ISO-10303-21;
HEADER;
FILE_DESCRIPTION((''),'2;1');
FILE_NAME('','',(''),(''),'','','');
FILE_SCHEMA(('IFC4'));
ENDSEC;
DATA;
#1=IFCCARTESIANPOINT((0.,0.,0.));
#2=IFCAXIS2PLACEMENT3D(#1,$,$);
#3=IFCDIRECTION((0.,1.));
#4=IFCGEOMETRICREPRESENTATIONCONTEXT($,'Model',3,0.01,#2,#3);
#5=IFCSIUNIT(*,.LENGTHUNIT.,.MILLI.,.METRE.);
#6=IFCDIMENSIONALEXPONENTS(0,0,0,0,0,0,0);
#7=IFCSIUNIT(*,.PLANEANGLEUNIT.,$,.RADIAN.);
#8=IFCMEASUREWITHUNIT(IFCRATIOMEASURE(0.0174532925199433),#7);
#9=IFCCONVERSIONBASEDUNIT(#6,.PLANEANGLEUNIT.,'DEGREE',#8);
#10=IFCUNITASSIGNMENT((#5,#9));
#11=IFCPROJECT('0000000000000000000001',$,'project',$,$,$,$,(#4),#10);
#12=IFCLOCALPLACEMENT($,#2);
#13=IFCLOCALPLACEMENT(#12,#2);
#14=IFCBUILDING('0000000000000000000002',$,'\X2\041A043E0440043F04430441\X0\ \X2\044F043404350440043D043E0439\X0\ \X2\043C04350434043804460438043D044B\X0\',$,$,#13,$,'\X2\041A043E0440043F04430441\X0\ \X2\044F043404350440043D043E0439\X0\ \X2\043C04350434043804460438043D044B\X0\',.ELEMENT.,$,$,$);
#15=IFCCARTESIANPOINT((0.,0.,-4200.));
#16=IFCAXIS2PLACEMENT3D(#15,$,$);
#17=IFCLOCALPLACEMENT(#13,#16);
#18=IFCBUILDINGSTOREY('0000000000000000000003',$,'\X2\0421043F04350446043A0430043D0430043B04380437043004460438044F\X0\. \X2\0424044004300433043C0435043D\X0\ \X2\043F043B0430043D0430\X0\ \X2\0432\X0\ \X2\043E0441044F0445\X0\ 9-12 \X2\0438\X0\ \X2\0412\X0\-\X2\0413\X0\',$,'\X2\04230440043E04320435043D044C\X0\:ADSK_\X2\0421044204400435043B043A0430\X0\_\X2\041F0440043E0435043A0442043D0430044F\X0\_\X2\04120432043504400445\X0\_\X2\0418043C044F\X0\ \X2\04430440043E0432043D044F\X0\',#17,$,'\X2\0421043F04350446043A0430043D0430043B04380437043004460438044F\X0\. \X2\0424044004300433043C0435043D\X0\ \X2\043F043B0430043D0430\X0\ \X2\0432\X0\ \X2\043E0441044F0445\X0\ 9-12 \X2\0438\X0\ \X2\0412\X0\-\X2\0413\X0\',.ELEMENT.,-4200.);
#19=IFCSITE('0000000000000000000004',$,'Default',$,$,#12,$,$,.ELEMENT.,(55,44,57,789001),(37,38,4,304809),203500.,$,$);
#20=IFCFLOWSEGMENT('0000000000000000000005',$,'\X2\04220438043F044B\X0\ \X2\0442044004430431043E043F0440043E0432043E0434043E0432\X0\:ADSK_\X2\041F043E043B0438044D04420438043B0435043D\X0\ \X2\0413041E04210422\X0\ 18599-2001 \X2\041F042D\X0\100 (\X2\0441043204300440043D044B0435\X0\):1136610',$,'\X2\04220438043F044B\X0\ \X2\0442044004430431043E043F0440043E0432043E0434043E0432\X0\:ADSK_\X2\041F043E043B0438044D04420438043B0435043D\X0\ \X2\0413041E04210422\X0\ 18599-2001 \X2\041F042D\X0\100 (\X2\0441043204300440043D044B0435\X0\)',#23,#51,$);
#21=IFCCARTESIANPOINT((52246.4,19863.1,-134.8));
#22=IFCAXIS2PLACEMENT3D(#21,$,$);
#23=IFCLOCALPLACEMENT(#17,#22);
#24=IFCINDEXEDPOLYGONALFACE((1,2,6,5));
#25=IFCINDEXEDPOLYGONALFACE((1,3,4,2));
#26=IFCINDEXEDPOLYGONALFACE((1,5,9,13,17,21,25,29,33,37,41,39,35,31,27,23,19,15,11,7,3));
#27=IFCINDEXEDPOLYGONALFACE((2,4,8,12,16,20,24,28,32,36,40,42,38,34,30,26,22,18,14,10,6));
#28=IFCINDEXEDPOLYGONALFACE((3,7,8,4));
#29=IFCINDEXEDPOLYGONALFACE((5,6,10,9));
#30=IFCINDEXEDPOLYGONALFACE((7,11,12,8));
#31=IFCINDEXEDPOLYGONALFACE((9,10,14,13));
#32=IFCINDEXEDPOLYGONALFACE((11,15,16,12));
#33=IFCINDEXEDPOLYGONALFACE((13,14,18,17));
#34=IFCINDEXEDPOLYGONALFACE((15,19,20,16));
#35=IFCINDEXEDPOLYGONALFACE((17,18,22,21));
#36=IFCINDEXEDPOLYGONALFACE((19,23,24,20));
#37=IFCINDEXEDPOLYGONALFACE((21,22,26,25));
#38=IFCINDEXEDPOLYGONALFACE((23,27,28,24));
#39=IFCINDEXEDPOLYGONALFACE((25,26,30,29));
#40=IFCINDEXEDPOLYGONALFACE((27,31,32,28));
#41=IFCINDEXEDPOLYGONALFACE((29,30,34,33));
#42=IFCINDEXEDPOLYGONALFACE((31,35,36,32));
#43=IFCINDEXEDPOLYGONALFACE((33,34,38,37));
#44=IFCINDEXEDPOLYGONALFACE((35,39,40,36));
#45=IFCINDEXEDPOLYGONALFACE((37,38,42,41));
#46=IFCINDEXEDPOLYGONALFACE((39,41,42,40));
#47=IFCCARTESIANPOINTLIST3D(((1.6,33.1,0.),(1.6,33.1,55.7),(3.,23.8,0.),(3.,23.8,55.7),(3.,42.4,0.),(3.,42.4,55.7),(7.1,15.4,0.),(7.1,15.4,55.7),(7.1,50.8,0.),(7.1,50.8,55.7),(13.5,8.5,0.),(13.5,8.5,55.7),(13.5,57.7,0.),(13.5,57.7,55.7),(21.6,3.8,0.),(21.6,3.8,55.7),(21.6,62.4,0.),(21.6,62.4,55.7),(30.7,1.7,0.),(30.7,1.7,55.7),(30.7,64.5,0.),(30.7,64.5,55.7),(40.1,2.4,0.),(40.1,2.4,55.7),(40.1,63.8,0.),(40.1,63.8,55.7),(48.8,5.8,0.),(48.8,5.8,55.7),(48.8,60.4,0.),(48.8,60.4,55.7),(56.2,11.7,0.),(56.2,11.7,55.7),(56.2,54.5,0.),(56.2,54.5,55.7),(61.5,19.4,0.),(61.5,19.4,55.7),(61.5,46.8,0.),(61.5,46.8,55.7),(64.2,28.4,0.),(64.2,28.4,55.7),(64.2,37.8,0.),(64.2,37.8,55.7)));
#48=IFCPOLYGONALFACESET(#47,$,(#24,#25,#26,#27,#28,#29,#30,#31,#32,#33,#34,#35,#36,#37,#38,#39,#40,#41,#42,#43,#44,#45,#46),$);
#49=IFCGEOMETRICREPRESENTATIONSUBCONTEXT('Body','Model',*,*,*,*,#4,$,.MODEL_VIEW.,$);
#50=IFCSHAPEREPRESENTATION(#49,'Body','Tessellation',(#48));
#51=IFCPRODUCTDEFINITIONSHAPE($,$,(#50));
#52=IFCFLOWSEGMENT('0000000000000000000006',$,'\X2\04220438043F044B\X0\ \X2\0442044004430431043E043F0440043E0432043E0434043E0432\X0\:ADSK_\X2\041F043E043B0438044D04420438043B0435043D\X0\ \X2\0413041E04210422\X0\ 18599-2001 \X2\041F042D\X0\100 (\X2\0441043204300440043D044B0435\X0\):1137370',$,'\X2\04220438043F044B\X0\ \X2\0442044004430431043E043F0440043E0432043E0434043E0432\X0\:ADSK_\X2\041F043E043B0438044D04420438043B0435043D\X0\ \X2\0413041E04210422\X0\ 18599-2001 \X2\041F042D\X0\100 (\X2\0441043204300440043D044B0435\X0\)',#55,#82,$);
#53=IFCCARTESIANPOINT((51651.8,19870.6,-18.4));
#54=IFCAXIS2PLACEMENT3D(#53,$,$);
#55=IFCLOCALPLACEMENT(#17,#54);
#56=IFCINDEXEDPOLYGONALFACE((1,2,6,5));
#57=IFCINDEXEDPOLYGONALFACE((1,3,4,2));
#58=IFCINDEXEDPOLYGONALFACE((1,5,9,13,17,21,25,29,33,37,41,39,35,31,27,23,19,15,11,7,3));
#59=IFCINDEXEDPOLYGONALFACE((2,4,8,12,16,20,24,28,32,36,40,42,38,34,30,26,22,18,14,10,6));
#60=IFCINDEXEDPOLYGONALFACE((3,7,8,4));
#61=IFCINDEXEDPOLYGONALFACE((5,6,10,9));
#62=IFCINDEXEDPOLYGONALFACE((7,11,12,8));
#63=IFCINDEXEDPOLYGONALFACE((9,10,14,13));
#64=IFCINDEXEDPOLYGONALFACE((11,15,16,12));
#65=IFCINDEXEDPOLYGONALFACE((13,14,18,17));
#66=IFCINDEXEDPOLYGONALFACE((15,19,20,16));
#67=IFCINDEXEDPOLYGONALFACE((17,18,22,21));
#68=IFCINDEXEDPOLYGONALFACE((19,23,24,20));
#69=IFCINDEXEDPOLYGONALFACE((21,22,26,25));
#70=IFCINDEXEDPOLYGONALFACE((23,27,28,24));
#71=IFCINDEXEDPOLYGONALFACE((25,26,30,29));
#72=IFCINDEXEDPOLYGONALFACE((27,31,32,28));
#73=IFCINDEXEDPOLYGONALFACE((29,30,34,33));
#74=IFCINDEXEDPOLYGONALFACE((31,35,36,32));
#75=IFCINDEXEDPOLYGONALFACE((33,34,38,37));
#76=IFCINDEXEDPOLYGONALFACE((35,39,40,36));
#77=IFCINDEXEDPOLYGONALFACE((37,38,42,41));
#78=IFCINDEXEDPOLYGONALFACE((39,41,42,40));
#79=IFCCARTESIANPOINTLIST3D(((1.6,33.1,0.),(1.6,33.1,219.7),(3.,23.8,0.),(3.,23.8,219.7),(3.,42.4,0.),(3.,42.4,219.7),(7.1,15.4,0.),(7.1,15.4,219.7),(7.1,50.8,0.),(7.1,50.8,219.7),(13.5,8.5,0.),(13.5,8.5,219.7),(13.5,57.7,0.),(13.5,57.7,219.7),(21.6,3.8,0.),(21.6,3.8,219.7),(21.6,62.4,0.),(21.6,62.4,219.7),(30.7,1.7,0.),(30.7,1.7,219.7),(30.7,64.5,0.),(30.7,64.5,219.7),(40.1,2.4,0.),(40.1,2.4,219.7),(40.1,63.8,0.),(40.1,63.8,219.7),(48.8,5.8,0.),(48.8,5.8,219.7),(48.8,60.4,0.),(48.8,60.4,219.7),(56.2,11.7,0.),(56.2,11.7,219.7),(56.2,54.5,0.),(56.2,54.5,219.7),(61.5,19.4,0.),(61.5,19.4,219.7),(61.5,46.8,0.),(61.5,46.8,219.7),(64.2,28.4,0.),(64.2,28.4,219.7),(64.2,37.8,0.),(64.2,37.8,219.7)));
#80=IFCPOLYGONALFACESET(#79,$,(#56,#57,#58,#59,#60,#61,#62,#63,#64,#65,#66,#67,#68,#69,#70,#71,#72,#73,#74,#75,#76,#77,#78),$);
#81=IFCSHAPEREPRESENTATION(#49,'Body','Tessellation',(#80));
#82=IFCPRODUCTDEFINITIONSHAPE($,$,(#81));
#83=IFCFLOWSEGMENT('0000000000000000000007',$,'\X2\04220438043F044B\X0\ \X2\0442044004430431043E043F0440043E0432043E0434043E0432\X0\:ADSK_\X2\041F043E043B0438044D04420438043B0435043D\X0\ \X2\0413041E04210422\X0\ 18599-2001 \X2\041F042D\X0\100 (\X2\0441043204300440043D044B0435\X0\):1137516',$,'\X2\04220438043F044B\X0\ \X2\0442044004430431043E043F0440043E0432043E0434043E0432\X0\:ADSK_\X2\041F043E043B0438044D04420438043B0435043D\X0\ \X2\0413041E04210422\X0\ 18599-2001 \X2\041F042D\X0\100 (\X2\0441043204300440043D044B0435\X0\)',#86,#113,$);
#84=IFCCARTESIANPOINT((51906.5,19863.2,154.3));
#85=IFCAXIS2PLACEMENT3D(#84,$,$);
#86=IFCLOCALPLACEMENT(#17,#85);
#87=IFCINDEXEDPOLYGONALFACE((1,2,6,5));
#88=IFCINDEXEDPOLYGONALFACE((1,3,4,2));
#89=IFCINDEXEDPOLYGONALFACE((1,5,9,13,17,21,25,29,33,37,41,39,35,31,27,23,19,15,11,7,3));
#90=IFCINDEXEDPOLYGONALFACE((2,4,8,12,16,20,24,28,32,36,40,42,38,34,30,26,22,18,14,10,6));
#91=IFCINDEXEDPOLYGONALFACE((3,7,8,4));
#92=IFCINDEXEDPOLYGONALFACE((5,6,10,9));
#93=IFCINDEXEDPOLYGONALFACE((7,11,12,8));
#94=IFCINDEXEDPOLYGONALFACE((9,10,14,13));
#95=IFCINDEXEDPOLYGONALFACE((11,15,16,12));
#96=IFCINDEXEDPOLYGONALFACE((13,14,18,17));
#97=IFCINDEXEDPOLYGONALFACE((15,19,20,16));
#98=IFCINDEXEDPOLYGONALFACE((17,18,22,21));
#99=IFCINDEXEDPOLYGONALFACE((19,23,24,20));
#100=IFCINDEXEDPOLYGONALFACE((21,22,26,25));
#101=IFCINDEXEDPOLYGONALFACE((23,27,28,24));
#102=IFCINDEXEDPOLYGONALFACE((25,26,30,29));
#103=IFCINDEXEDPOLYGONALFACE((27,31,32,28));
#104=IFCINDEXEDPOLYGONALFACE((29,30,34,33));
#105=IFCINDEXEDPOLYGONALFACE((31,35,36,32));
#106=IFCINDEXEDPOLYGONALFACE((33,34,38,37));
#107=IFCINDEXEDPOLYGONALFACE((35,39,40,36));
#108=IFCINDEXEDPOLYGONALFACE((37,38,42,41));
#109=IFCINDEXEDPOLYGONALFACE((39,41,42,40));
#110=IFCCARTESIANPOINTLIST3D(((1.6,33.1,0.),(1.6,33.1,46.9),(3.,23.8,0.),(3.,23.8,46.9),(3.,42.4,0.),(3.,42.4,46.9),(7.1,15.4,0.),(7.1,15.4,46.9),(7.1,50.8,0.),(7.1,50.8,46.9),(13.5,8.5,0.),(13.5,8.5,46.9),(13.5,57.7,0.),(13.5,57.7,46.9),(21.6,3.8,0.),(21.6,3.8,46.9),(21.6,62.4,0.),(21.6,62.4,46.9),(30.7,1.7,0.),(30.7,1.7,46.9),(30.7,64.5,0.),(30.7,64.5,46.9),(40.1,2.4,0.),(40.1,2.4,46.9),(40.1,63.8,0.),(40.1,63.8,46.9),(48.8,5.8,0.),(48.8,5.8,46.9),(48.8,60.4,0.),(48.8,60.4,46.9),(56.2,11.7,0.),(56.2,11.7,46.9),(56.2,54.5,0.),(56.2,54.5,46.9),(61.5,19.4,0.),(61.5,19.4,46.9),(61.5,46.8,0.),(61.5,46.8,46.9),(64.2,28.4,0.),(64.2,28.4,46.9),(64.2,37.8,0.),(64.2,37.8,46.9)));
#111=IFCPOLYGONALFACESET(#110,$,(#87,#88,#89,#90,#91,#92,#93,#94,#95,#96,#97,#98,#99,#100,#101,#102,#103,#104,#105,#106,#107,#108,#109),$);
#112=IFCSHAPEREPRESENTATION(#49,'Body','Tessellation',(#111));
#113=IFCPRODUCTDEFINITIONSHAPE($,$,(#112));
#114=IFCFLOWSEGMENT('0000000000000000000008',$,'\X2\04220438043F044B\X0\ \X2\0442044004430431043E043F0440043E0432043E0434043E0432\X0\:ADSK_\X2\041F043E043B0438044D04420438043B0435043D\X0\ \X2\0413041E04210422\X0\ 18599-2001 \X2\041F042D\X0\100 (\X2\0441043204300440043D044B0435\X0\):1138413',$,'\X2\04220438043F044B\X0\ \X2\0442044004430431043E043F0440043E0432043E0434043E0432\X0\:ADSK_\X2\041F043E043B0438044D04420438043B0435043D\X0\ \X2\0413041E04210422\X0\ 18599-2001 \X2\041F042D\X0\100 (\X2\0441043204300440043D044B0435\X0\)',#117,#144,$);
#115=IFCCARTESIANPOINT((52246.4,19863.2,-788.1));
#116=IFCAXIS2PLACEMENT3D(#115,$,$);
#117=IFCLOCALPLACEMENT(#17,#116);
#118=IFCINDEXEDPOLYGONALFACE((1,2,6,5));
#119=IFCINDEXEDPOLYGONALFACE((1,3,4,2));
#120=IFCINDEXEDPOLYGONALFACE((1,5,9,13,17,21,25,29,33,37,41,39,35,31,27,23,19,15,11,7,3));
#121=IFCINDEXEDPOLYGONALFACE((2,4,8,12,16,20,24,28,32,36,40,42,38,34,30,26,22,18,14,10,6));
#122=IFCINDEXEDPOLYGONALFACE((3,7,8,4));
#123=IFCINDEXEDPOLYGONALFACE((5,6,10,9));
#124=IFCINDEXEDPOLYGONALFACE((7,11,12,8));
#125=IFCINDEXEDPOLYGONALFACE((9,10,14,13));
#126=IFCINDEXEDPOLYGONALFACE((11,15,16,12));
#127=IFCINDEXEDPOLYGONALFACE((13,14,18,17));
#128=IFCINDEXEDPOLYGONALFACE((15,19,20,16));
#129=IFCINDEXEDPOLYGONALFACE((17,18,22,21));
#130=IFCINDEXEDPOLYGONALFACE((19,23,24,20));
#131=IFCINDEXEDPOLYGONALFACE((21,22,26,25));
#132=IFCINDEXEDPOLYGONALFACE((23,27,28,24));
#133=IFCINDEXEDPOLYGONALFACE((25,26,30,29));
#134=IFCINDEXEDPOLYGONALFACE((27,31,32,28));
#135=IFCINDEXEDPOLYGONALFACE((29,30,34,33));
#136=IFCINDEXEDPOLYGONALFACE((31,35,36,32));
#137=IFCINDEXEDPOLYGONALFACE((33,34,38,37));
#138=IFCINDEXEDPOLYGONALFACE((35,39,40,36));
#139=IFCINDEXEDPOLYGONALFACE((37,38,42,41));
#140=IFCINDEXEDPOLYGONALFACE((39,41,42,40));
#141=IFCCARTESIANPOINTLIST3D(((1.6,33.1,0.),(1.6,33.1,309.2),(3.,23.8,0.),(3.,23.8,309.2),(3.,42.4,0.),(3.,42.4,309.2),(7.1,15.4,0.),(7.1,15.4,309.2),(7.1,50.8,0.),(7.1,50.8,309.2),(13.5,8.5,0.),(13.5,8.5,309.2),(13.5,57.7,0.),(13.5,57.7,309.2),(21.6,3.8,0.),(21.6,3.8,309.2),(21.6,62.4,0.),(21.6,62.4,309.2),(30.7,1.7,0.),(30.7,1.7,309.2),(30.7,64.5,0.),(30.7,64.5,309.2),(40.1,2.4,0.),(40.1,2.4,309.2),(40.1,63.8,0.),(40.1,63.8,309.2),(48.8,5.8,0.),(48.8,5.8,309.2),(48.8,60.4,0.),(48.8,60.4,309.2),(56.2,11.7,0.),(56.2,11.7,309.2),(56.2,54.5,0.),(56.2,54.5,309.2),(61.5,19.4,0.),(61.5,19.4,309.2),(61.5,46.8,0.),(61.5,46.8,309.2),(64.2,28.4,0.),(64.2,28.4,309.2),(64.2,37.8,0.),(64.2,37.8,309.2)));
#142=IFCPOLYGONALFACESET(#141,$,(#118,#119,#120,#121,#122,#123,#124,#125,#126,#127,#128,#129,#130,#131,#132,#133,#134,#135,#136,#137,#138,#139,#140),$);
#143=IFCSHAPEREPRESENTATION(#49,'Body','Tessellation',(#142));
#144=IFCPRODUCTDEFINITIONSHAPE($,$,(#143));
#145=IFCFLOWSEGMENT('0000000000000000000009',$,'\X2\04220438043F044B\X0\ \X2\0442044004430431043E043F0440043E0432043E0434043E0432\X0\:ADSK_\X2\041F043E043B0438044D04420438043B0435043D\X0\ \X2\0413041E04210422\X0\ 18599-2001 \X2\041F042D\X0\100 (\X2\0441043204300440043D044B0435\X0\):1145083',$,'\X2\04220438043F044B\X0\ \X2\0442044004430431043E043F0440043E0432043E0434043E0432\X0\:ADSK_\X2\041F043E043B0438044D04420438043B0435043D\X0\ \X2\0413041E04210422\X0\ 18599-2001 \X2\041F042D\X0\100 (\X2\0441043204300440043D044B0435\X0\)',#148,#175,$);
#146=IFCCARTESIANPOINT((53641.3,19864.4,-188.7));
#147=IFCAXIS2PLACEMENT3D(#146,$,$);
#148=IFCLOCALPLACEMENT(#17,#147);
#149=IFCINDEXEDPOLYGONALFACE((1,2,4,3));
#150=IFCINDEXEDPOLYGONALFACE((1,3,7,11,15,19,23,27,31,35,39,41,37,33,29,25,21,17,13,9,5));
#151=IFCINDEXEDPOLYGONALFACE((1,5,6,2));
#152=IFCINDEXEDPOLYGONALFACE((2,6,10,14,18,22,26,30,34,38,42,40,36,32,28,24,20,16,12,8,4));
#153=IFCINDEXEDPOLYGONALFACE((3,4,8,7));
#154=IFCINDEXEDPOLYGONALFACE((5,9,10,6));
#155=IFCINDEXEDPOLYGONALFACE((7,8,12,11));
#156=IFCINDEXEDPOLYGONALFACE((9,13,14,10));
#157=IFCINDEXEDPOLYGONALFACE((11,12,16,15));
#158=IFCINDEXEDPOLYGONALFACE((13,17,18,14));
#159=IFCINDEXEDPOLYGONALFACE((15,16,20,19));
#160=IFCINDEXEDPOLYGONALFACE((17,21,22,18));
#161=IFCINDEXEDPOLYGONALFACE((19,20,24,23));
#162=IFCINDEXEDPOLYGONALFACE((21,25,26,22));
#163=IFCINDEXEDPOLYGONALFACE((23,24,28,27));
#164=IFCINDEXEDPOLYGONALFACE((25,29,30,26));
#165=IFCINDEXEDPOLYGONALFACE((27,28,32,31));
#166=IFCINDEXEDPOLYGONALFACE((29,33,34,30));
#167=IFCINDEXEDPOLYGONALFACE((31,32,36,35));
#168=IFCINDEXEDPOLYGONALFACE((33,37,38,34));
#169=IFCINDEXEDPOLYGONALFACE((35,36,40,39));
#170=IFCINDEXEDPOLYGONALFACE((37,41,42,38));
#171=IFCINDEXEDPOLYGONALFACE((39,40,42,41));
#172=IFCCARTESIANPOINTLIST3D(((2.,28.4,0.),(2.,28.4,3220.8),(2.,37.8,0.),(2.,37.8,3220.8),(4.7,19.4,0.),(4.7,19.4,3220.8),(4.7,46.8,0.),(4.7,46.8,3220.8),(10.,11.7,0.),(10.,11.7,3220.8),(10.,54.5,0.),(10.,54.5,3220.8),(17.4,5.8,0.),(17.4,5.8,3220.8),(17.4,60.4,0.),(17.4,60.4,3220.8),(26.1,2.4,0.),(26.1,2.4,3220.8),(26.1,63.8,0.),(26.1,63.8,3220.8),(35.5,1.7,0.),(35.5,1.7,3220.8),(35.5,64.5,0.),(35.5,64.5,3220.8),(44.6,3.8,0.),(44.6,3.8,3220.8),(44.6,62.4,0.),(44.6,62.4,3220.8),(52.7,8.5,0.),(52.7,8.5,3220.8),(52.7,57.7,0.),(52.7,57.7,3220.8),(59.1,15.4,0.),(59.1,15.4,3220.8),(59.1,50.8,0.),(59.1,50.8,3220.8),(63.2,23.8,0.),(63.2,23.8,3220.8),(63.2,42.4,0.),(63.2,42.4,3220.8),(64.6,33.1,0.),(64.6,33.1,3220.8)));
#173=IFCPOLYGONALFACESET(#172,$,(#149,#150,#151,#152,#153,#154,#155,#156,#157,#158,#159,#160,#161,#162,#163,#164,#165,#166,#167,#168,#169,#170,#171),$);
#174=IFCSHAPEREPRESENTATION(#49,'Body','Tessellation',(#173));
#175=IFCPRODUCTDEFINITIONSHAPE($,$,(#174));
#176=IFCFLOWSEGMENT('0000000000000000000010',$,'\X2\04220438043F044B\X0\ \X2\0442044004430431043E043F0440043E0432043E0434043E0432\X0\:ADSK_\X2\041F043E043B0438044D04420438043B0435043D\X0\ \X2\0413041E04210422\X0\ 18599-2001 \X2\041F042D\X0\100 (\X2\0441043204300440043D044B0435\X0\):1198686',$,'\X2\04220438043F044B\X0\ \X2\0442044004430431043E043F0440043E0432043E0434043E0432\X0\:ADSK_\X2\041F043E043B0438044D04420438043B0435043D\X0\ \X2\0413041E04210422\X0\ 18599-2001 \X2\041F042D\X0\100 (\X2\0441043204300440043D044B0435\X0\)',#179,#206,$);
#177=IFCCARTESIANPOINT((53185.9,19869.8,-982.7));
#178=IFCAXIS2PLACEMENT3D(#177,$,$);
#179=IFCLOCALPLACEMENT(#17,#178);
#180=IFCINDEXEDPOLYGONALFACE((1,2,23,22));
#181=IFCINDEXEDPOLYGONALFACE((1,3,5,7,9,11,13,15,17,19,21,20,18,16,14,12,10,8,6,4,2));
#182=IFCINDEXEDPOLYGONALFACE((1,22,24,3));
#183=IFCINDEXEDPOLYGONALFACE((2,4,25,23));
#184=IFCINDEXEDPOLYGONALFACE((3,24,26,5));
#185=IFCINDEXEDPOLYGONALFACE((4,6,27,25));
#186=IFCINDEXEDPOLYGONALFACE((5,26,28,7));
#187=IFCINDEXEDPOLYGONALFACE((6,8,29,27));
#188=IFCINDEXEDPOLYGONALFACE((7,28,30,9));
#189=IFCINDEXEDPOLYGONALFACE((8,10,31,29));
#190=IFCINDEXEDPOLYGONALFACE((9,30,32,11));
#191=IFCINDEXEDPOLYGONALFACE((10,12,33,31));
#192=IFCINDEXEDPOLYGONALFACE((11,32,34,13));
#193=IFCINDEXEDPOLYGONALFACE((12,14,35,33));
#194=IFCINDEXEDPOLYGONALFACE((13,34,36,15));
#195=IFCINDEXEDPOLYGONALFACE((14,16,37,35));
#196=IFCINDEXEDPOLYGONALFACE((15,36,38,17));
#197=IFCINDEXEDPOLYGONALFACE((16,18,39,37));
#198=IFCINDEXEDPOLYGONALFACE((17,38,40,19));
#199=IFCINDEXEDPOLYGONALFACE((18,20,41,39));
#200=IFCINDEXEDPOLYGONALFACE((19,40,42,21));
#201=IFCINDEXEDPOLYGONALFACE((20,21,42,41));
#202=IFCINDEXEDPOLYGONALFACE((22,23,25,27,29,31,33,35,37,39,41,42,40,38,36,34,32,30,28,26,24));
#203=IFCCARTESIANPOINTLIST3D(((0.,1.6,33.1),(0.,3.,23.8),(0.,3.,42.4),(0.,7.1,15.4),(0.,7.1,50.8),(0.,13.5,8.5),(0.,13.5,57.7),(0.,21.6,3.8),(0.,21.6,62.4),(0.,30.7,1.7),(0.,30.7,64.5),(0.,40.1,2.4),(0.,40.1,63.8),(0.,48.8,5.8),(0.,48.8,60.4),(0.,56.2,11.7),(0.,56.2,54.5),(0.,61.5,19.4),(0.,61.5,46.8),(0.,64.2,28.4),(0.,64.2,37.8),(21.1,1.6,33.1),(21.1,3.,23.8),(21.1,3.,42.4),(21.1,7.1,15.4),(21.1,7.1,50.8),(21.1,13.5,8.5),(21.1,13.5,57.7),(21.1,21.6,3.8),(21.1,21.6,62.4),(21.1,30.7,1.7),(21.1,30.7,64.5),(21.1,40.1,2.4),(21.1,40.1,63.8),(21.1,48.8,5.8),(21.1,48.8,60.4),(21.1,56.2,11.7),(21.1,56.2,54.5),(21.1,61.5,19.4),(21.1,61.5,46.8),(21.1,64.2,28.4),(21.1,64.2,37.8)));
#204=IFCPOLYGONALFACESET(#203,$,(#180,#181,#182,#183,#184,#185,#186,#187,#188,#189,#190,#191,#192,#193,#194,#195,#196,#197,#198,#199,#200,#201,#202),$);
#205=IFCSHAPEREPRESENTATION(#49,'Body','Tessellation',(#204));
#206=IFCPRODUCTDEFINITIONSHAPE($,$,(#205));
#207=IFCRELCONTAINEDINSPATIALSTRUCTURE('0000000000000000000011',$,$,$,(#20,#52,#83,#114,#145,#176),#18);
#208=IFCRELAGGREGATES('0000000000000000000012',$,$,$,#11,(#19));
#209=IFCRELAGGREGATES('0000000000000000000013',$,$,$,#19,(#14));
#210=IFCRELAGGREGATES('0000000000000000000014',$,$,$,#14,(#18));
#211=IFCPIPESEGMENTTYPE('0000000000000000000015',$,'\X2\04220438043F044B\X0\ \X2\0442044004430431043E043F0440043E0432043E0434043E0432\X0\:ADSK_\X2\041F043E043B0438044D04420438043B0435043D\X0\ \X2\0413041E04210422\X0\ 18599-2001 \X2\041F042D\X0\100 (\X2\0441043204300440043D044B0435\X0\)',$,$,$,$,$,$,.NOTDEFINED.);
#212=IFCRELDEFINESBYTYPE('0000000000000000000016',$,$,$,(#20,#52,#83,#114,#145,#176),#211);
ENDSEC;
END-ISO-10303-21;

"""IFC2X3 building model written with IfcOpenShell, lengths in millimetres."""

from ifc_helpers import new_model, entity, si_unit, converted_unit, direction, frame, frame_2d, origin, origin_2d_with_axis, place, context, subcontext, project, spatial, circle, extrude, type_object, element, save


model = new_model("IFC2X3")

# Units and contexts
model_context = context("Model", 3, precision=0.01, world=origin(), true_north=direction((0.0, 1.0)))
body_context = subcontext(model_context, "Body", "Model", "MODEL_VIEW")
ifc_project = project(units=[si_unit("LENGTHUNIT", "METRE", prefix="MILLI"), converted_unit("PLANEANGLEUNIT", "DEGREE", entity("IfcRatioMeasure", 0.0174532925199433), si_unit("PLANEANGLEUNIT", "RADIAN"), dimensions=[0, 0, 0, 0, 0, 0, 0])], contexts=[model_context])

# Site, building, storey
site_placement = place(None, frame((0.0, 0.0, 0.0)))
site = spatial("IfcSite", under=ifc_project, at=site_placement, Name="Default", CompositionType="ELEMENT", RefLatitude=(55, 44, 57, 789001), RefLongitude=(37, 38, 4, 304809), RefElevation=203500.0)
building_placement = place(site_placement, origin())
building = spatial("IfcBuilding", under=site, at=building_placement, Name="Корпус ядерной медицины", LongName="Корпус ядерной медицины", CompositionType="ELEMENT")
storey_placement = place(building_placement, frame((0.0, 0.0, -4200.0)))
storey = spatial("IfcBuildingStorey", under=building, at=storey_placement, Name="Спецканализация. Фрагмен плана в осях 9-12 и В-Г", ObjectType="Уровень:ADSK_Стрелка_Проектная_Вверх_Имя уровня", LongName="Спецканализация. Фрагмен плана в осях 9-12 и В-Г", CompositionType="ELEMENT", Elevation=-4200.0)

# Flow segments
pipe_segment_type = type_object("IfcPipeSegmentType", Name="Типы трубопроводов:ADSK_Полиэтилен ГОСТ 18599-2001 ПЭ100 (сварные)", PredefinedType="NOTDEFINED")
flow_segment_1_placement = place(storey_placement, frame((52246.4, 19863.1, -134.8)))
element("IfcFlowSegment", 1, at=flow_segment_1_placement, inside=storey, type_object=pipe_segment_type, Name="Типы трубопроводов:ADSK_Полиэтилен ГОСТ 18599-2001 ПЭ100 (сварные):1136610", ObjectType="Типы трубопроводов:ADSK_Полиэтилен ГОСТ 18599-2001 ПЭ100 (сварные)", context=body_context, shape_type="SweptSolid", body=[
    extrude(circle(Radius=31.5, at=origin_2d_with_axis()), frame((33.1, 33.1, 0.0), z_axis=(0.0, 0.0, 1.0), x_axis=(-1.0, 0.0, 0.0)), (0.0, 0.0, 1.0), 55.7),
])
flow_segment_2_placement = place(storey_placement, frame((51651.8, 19870.6, -18.4)))
element("IfcFlowSegment", 2, at=flow_segment_2_placement, inside=storey, type_object=pipe_segment_type, Name="Типы трубопроводов:ADSK_Полиэтилен ГОСТ 18599-2001 ПЭ100 (сварные):1137370", ObjectType="Типы трубопроводов:ADSK_Полиэтилен ГОСТ 18599-2001 ПЭ100 (сварные)", context=body_context, shape_type="SweptSolid", body=[
    extrude(circle(Radius=31.5, at=origin_2d_with_axis()), frame((33.1, 33.1, 0.0), z_axis=(0.0, 0.0, 1.0), x_axis=(-1.0, 0.0, 0.0)), (0.0, 0.0, 1.0), 219.7),
])
flow_segment_3_placement = place(storey_placement, frame((51906.5, 19863.2, 154.3)))
element("IfcFlowSegment", 3, at=flow_segment_3_placement, inside=storey, type_object=pipe_segment_type, Name="Типы трубопроводов:ADSK_Полиэтилен ГОСТ 18599-2001 ПЭ100 (сварные):1137516", ObjectType="Типы трубопроводов:ADSK_Полиэтилен ГОСТ 18599-2001 ПЭ100 (сварные)", context=body_context, shape_type="SweptSolid", body=[
    extrude(circle(Radius=31.5, at=origin_2d_with_axis()), frame((33.1, 33.1, 0.0), z_axis=(0.0, 0.0, 1.0), x_axis=(-1.0, 0.0, 0.0)), (0.0, 0.0, 1.0), 46.9),
])
flow_segment_4_placement = place(storey_placement, frame((52246.4, 19863.2, -788.1)))
element("IfcFlowSegment", 4, at=flow_segment_4_placement, inside=storey, type_object=pipe_segment_type, Name="Типы трубопроводов:ADSK_Полиэтилен ГОСТ 18599-2001 ПЭ100 (сварные):1138413", ObjectType="Типы трубопроводов:ADSK_Полиэтилен ГОСТ 18599-2001 ПЭ100 (сварные)", context=body_context, shape_type="SweptSolid", body=[
    extrude(circle(Radius=31.5, at=origin_2d_with_axis()), frame((33.1, 33.1, 0.0), z_axis=(0.0, 0.0, 1.0), x_axis=(-1.0, 0.0, 0.0)), (0.0, 0.0, 1.0), 309.2),
])
flow_segment_5_placement = place(storey_placement, frame((53641.3, 19864.4, -188.7)))
element("IfcFlowSegment", 5, at=flow_segment_5_placement, inside=storey, type_object=pipe_segment_type, Name="Типы трубопроводов:ADSK_Полиэтилен ГОСТ 18599-2001 ПЭ100 (сварные):1145083", ObjectType="Типы трубопроводов:ADSK_Полиэтилен ГОСТ 18599-2001 ПЭ100 (сварные)", context=body_context, shape_type="SweptSolid", body=[
    extrude(circle(Radius=31.5, at=origin_2d_with_axis()), frame((33.1, 33.1, 0.0)), (0.0, 0.0, 1.0), 3220.8),
])
flow_segment_6_placement = place(storey_placement, frame((53185.9, 19869.8, -982.7)))
element("IfcFlowSegment", 6, at=flow_segment_6_placement, inside=storey, type_object=pipe_segment_type, Name="Типы трубопроводов:ADSK_Полиэтилен ГОСТ 18599-2001 ПЭ100 (сварные):1198686", ObjectType="Типы трубопроводов:ADSK_Полиэтилен ГОСТ 18599-2001 ПЭ100 (сварные)", context=body_context, shape_type="SweptSolid", body=[
    extrude(circle(Radius=31.5, at=frame_2d((0.0, 0.0), x_axis=(1.0, 0.0))), frame((0.0, 33.1, 33.1), z_axis=(1.0, 0.0, 0.0), x_axis=(0.0, -1.0, 0.0)), (0.0, 0.0, 1.0), 21.1),
])

save(model, "model.ifc")
